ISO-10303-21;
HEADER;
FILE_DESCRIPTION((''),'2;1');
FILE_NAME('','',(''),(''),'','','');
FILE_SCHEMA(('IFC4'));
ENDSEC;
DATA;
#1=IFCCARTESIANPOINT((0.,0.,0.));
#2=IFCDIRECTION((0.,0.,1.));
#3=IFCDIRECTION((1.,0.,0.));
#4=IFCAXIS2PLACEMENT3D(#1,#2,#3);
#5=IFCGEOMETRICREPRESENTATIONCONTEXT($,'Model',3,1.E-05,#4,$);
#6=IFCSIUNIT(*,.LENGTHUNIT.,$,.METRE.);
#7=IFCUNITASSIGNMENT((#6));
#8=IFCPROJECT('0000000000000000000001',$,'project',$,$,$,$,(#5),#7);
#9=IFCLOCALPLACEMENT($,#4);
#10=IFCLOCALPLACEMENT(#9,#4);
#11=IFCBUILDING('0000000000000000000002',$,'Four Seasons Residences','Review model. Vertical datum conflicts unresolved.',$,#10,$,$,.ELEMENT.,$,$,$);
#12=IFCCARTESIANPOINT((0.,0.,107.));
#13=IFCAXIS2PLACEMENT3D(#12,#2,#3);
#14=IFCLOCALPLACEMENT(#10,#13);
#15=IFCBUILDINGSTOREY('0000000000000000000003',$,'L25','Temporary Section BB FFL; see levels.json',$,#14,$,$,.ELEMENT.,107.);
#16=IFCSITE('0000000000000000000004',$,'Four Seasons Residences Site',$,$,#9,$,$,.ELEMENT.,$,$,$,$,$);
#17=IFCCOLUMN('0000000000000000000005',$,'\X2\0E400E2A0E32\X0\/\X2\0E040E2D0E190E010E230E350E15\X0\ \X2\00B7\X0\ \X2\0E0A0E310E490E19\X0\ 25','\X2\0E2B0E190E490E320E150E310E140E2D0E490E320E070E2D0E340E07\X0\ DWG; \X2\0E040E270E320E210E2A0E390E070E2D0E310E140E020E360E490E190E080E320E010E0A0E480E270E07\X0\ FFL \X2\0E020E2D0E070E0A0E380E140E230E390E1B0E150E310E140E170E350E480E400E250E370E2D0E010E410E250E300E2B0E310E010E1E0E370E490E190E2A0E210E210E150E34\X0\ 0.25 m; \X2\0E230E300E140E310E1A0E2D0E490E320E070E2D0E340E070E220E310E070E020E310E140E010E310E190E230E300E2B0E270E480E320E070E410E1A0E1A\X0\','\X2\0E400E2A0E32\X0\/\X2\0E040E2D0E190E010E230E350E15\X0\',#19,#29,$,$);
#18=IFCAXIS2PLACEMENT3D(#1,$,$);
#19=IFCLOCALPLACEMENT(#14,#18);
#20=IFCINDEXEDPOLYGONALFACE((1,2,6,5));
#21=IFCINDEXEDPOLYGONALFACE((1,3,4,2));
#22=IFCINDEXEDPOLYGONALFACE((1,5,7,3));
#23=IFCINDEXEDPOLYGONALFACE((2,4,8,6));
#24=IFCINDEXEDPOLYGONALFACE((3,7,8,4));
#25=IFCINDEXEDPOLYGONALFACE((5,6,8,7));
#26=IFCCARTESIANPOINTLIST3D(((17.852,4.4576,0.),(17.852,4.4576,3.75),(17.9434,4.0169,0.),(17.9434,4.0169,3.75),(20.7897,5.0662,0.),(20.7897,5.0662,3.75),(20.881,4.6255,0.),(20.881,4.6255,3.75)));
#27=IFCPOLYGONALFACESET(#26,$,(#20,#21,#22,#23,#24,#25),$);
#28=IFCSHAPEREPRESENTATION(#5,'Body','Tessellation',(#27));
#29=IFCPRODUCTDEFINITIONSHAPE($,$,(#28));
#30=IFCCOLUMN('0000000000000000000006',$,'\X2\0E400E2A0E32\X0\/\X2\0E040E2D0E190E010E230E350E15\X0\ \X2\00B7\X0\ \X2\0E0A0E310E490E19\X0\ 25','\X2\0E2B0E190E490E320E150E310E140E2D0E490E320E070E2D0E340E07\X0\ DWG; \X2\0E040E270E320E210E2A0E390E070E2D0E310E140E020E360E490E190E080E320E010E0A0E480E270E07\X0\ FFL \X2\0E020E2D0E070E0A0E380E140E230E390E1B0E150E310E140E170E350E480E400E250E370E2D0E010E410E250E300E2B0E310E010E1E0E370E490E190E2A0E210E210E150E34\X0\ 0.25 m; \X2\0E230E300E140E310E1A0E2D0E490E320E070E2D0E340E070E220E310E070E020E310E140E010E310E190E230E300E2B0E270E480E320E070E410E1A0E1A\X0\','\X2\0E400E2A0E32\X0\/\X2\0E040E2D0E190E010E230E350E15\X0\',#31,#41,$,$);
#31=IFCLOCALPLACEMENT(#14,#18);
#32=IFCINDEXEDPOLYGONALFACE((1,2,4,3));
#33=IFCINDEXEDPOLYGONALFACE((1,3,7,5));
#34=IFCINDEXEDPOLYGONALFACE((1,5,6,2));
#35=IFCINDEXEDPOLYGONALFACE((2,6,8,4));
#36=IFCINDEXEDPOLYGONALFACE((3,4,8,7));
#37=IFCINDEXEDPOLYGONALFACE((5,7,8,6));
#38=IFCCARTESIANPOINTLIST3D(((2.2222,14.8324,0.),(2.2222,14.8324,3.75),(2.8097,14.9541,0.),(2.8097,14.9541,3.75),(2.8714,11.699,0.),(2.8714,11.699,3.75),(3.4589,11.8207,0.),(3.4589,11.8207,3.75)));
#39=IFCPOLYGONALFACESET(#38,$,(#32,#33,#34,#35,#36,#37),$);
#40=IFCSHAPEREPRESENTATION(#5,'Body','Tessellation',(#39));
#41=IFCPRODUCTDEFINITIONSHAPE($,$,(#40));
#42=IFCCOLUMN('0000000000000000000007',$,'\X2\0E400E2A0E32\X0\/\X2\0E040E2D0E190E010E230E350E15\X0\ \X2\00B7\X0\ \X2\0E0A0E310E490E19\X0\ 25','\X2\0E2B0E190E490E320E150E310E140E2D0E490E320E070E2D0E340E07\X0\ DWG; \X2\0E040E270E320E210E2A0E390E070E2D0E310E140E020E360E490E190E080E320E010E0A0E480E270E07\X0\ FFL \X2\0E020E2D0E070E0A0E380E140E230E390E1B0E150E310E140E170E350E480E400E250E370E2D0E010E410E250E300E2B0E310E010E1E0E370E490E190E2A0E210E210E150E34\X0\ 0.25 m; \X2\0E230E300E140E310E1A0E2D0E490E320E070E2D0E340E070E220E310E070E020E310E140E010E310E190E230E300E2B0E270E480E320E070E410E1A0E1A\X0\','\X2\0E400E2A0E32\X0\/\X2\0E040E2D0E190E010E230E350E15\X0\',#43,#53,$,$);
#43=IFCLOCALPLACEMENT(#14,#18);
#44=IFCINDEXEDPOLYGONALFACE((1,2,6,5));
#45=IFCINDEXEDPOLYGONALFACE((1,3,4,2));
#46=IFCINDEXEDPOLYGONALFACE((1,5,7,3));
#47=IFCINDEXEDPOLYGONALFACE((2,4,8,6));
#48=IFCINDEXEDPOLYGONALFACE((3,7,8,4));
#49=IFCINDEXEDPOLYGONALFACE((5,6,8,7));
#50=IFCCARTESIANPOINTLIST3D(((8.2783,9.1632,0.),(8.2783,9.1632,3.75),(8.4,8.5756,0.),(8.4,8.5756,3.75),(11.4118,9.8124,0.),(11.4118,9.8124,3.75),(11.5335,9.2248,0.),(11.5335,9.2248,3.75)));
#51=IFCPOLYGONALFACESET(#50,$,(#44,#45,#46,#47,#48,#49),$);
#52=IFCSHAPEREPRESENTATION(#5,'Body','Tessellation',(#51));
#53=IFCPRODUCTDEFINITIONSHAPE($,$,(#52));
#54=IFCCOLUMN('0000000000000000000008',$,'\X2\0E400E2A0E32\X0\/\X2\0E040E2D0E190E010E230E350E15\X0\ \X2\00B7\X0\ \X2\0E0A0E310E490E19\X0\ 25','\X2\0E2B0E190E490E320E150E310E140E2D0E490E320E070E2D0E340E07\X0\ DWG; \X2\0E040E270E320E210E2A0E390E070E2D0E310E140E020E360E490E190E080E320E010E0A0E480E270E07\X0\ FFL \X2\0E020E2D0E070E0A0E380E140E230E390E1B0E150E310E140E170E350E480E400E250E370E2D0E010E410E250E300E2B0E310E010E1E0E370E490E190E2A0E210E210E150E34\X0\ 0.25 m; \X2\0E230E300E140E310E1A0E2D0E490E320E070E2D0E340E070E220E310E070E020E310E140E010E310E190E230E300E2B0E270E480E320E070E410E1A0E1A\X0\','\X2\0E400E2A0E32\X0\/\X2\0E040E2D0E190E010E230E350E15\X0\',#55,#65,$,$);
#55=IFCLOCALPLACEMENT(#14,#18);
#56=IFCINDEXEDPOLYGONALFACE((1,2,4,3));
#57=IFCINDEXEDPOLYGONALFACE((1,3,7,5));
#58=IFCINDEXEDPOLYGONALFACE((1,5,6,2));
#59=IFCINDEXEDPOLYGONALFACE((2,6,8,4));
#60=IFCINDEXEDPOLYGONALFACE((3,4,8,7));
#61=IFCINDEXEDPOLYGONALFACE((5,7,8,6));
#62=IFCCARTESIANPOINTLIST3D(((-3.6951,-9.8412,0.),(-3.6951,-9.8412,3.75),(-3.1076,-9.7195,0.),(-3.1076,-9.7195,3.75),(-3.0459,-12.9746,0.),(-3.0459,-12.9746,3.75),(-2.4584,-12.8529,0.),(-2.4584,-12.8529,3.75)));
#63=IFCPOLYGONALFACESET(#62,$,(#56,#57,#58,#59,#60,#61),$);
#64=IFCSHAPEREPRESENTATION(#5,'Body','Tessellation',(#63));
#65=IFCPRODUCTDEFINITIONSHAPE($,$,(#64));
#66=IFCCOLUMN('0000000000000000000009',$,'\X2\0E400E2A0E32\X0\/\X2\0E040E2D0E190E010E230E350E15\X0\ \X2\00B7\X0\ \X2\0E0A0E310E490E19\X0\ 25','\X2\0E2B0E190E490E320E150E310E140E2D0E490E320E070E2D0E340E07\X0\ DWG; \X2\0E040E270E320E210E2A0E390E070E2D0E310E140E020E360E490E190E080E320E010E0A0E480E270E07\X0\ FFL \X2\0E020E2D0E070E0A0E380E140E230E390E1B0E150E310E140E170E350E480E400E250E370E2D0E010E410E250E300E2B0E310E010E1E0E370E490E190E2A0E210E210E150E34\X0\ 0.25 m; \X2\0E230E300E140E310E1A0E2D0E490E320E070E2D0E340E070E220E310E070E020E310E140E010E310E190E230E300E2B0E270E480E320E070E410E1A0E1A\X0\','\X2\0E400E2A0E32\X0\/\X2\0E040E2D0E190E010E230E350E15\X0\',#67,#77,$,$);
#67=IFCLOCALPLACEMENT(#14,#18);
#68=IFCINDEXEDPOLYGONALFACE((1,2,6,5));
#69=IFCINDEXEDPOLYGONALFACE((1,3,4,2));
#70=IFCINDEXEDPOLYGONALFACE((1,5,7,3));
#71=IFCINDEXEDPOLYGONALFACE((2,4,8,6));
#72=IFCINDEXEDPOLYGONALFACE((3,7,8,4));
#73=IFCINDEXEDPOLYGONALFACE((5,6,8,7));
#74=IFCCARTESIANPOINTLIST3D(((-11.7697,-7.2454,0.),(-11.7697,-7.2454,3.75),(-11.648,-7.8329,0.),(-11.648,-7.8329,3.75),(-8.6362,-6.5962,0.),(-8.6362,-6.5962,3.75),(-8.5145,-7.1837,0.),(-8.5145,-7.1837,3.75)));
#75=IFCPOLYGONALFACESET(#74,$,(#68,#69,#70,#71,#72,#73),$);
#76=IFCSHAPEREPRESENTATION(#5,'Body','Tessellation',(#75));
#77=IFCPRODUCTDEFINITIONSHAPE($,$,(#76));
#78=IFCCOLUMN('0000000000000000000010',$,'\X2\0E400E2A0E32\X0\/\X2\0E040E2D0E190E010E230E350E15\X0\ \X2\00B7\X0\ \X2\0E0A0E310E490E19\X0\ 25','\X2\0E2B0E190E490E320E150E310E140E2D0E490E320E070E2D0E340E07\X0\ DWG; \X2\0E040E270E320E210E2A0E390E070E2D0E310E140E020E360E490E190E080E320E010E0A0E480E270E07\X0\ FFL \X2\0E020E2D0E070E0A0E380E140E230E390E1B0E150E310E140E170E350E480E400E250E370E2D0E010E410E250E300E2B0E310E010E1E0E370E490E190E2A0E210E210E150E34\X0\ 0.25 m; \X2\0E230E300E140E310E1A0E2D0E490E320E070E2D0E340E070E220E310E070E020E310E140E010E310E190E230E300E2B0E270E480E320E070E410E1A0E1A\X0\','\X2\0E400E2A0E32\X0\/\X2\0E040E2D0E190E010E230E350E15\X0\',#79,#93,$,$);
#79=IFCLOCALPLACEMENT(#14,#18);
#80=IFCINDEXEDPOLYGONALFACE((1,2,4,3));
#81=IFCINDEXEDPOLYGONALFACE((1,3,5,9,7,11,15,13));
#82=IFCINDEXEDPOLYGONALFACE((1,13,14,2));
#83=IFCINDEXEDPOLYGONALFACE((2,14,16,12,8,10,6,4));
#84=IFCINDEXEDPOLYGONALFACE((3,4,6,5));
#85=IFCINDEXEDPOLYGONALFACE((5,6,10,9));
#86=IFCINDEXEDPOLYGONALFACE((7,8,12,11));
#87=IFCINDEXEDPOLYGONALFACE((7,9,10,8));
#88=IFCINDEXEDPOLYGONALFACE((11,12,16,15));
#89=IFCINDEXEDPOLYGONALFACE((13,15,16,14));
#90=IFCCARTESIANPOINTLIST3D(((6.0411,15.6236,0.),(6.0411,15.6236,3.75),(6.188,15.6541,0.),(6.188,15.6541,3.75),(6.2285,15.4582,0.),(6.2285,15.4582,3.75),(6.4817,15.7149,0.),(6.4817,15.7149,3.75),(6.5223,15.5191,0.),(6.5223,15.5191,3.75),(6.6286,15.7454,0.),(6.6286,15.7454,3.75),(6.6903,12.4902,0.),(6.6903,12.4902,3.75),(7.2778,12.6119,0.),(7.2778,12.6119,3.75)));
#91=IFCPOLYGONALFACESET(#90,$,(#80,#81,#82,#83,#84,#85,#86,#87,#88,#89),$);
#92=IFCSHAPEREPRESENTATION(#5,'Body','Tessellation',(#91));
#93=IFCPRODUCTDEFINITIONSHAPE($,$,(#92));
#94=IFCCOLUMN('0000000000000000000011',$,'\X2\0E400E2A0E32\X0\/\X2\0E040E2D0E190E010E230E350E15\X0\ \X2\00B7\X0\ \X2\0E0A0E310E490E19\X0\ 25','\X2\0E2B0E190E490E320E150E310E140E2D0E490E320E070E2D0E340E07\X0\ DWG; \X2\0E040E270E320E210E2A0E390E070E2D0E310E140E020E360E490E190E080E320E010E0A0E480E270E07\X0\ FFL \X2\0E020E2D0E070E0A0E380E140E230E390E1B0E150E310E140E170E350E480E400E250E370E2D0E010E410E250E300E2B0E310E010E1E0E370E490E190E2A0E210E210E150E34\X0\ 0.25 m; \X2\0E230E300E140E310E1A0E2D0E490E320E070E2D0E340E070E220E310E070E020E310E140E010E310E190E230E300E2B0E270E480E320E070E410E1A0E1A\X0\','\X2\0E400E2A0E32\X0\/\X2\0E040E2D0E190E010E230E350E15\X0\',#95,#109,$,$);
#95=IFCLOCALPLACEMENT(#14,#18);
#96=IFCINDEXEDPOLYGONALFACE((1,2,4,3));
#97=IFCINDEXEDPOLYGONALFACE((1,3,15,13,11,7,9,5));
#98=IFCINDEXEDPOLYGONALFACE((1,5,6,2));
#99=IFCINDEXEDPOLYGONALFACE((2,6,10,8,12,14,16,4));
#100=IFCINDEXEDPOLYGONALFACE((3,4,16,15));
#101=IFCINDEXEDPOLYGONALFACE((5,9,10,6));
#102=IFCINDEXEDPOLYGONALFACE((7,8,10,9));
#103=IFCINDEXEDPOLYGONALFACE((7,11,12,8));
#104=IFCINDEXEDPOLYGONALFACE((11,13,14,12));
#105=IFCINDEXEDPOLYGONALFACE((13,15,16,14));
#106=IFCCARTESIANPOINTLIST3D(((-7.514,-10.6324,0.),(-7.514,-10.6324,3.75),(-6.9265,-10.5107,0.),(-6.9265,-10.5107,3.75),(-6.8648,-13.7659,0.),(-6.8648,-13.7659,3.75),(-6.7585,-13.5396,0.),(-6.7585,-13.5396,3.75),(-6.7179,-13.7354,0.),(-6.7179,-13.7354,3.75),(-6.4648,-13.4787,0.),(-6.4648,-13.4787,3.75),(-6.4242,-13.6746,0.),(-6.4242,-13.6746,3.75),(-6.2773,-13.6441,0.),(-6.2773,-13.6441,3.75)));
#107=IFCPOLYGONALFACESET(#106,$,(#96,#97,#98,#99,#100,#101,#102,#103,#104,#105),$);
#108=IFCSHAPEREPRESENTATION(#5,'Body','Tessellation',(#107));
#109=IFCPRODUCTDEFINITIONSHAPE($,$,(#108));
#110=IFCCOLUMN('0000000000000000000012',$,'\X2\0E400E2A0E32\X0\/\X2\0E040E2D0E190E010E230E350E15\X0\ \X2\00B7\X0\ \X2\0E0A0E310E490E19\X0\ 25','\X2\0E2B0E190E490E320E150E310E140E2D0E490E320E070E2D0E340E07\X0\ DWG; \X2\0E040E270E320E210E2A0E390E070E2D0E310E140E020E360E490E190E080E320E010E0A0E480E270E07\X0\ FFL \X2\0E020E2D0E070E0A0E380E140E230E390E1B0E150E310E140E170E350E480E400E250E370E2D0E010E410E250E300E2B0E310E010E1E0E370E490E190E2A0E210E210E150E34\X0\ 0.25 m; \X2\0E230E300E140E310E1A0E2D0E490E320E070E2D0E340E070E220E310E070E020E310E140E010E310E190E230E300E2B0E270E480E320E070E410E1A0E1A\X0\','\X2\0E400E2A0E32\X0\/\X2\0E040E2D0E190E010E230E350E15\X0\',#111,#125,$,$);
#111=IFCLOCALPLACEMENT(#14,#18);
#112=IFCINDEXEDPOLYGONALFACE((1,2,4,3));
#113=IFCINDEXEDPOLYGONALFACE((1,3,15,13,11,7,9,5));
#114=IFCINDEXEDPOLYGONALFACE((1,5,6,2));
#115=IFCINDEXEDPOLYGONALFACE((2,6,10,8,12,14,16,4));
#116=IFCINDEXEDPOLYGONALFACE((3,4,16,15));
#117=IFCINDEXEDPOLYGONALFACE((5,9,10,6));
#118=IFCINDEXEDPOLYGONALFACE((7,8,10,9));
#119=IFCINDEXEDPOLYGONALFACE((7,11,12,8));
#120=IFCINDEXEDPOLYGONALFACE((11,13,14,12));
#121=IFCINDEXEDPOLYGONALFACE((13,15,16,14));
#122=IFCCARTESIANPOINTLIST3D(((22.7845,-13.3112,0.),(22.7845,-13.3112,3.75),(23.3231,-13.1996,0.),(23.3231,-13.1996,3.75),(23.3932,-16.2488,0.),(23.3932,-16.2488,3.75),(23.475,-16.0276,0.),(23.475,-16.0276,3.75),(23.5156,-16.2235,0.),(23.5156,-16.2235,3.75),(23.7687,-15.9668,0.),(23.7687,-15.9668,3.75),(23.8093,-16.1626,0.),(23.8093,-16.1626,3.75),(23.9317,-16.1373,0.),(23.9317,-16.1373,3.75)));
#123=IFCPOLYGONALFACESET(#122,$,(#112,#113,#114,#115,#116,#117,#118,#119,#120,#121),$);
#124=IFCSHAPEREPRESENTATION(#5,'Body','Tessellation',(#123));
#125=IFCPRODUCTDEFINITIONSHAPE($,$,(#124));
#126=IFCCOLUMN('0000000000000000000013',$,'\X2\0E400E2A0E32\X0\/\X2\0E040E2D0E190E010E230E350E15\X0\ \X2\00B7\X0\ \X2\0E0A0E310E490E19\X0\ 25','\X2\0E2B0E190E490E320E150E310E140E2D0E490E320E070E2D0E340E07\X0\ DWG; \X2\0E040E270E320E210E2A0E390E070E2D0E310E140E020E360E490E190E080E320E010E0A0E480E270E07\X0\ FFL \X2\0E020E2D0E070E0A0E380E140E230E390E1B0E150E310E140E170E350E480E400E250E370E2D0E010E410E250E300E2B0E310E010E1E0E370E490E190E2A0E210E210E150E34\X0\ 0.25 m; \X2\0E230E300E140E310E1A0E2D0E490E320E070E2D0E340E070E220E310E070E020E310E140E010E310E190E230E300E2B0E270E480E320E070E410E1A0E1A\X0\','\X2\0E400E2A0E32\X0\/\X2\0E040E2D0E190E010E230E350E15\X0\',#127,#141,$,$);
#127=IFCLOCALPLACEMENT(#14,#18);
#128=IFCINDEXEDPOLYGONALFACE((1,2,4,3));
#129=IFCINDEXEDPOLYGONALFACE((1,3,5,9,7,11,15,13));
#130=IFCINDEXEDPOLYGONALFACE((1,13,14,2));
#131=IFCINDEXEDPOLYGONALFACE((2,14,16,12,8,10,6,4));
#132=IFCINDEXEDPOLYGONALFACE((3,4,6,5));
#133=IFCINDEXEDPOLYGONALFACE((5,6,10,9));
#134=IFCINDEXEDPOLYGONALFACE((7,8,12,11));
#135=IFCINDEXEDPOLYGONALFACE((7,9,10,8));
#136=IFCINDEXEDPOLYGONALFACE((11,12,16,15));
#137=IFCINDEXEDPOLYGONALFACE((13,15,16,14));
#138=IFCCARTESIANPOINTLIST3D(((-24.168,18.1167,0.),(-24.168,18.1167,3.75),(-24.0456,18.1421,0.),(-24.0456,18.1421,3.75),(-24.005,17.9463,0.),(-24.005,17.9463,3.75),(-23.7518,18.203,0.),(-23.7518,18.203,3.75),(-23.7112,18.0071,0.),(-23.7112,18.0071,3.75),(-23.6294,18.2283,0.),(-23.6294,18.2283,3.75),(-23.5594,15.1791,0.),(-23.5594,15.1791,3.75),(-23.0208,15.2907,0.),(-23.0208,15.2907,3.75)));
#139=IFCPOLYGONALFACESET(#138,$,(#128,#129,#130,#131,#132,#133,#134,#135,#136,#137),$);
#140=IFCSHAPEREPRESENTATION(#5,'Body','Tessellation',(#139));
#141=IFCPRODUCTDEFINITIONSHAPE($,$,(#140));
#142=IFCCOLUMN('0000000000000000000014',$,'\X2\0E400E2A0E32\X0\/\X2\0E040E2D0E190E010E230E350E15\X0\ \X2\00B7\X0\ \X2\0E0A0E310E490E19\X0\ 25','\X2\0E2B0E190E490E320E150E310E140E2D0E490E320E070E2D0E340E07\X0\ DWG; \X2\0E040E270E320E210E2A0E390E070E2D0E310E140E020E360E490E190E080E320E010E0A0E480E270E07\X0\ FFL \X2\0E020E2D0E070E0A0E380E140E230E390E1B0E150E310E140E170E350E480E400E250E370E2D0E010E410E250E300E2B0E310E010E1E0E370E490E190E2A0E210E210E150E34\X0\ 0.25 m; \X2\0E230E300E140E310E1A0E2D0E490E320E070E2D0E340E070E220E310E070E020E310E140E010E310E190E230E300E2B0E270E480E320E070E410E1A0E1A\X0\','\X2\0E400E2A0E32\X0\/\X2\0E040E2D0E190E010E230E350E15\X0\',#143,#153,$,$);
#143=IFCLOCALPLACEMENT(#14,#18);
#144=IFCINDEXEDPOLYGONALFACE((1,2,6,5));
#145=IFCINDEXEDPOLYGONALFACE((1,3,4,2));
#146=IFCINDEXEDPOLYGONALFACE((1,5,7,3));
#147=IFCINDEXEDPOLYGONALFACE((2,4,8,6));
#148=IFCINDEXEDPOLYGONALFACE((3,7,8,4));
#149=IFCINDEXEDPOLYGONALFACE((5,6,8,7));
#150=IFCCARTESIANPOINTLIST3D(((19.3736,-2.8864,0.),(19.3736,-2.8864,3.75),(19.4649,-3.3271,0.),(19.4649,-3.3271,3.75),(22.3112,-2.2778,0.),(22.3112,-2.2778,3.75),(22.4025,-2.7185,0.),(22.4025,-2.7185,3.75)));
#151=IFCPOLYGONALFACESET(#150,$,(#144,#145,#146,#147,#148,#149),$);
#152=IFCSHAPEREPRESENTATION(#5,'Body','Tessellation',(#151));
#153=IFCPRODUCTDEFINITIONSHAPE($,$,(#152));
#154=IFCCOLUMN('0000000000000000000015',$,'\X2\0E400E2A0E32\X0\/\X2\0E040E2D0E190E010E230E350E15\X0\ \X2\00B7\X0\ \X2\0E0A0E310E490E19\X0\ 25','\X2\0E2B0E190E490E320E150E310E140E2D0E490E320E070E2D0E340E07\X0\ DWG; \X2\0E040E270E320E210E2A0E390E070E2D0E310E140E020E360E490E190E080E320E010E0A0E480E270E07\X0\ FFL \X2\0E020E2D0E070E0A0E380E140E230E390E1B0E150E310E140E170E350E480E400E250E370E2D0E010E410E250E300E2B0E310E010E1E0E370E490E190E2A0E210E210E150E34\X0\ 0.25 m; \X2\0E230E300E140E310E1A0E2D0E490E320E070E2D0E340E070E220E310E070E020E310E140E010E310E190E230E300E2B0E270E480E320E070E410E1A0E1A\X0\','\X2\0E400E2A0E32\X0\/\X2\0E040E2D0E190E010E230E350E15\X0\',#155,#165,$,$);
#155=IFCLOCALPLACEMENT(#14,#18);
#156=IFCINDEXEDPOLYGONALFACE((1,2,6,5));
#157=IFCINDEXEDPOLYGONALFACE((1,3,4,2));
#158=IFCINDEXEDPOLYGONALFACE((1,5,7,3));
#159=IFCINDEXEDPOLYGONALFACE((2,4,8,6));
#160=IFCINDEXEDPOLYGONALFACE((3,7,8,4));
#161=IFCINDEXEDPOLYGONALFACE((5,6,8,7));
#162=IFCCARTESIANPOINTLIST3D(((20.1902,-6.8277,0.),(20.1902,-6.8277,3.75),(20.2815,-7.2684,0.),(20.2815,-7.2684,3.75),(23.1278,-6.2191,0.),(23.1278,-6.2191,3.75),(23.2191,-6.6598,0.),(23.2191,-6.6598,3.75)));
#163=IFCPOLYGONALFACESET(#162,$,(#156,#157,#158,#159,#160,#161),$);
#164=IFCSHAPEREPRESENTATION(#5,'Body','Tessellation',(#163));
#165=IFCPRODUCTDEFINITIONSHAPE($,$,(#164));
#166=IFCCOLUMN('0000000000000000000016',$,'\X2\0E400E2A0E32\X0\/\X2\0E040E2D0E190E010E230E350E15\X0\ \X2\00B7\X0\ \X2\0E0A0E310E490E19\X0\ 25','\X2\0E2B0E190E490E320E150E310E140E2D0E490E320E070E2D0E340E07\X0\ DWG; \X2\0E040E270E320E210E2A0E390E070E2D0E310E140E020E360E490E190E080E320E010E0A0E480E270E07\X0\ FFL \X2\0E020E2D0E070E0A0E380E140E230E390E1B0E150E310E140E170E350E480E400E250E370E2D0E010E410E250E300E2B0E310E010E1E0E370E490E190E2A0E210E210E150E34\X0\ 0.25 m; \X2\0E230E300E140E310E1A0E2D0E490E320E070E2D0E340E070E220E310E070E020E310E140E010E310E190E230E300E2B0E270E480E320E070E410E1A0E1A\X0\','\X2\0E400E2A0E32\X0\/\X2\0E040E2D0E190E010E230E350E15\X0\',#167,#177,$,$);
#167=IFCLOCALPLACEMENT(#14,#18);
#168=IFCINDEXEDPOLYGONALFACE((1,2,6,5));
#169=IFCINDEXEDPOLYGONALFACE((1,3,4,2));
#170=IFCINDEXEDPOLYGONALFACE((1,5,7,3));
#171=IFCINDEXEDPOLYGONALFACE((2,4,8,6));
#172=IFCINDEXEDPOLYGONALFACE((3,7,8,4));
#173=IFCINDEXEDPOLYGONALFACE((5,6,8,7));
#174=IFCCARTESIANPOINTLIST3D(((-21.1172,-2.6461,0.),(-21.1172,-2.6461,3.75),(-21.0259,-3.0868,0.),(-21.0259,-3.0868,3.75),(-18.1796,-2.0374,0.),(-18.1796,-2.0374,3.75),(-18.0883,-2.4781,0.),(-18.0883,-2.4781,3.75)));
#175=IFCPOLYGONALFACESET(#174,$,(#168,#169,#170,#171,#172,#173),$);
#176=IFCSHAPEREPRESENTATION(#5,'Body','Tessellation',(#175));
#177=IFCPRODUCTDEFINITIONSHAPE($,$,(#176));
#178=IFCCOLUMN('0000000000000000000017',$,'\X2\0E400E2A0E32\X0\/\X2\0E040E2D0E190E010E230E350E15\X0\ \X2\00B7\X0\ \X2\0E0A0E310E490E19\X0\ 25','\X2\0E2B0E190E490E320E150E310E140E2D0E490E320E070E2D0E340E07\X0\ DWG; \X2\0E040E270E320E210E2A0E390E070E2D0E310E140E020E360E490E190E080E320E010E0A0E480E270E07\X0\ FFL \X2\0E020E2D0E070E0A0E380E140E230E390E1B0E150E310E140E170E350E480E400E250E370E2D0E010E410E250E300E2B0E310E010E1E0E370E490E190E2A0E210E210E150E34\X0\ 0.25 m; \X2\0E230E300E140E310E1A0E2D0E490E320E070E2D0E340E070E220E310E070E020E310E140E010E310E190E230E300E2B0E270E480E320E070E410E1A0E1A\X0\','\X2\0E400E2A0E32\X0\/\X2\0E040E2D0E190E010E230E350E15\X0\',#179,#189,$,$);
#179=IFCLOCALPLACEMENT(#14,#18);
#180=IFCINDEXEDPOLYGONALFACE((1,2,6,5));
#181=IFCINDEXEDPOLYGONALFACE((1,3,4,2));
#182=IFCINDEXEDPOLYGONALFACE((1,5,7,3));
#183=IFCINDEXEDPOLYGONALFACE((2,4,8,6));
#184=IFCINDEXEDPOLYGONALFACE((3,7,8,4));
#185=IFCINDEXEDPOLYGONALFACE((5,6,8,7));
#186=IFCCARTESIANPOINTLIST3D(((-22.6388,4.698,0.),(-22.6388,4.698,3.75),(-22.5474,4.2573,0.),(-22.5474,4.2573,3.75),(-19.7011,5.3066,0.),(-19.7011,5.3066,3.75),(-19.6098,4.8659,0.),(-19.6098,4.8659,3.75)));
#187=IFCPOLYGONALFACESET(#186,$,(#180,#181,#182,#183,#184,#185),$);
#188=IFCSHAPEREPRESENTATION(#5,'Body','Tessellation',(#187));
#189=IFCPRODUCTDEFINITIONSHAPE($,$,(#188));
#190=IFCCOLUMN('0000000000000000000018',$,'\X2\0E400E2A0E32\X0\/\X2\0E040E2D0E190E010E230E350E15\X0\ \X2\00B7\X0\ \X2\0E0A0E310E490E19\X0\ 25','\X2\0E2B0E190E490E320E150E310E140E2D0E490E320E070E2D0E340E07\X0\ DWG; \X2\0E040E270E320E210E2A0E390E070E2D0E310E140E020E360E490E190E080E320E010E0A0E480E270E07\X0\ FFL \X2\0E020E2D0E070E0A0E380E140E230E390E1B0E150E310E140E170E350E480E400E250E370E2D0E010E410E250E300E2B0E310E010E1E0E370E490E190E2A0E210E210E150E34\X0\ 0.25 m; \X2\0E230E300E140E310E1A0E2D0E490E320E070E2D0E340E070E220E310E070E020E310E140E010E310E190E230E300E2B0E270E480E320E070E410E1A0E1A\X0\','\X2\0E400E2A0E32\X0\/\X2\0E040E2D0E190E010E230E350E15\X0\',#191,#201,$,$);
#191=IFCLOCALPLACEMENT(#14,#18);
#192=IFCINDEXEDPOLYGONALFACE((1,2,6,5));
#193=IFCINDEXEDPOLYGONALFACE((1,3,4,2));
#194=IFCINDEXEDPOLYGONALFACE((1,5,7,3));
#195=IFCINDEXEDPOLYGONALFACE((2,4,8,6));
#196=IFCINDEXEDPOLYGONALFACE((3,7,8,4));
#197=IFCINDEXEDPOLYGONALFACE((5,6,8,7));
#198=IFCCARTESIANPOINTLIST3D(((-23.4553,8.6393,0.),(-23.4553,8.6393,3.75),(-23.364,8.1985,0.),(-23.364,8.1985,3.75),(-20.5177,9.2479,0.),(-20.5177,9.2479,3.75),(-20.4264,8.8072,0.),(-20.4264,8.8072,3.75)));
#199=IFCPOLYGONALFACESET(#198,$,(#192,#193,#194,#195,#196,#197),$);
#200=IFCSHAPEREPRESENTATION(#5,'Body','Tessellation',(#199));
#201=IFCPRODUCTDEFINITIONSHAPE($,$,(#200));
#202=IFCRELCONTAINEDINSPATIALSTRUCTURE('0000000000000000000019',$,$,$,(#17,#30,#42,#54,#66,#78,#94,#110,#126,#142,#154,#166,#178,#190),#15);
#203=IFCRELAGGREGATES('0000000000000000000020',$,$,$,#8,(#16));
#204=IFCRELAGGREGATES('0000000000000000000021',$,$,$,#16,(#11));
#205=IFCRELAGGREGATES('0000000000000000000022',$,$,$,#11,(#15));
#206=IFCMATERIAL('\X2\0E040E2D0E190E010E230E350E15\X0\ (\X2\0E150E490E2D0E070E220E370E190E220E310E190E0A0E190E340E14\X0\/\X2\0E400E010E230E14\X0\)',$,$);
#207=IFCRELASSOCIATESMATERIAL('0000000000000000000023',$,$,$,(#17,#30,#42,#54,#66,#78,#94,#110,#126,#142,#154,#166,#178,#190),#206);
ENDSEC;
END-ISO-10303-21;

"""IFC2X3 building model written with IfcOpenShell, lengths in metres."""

from ifc_helpers import new_model, si_unit, frame, origin_with_axes, place, context, project, spatial, polyline, outline, extrude, material, element, save


model = new_model("IFC2X3")

# Units and contexts
model_context = context("Model", 3, precision=1e-05, world=origin_with_axes())
ifc_project = project(units=[si_unit("LENGTHUNIT", "METRE")], contexts=[model_context])

# Site, building, storey
site_placement = place(None, origin_with_axes())
site = spatial("IfcSite", under=ifc_project, at=site_placement, Name="Four Seasons Residences Site", CompositionType="ELEMENT")
building_placement = place(site_placement, origin_with_axes())
building = spatial("IfcBuilding", under=site, at=building_placement, Name="Four Seasons Residences", Description="Review model. Vertical datum conflicts unresolved.", CompositionType="ELEMENT")
storey_placement = place(building_placement, frame((0.0, 0.0, 107.0), z_axis=(0.0, 0.0, 1.0), x_axis=(1.0, 0.0, 0.0)))
storey = spatial("IfcBuildingStorey", under=building, at=storey_placement, Name="L25", Description="Temporary Section BB FFL; see levels.json", CompositionType="ELEMENT", Elevation=107.0)

# Columns
ifc_material_1 = material(Name="คอนกรีต (ต้องยืนยันชนิด/เกรด)")
column_1_placement = place(storey_placement, origin_with_axes())
element("IfcColumn", 1, at=column_1_placement, inside=storey, material=ifc_material_1, Name="เสา/คอนกรีต · ชั้น 25", Description="หน้าตัดอ้างอิง DWG; ความสูงอัดขึ้นจากช่วง FFL ของชุดรูปตัดที่เลือกและหักพื้นสมมติ 0.25 m; ระดับอ้างอิงยังขัดกันระหว่างแบบ", ObjectType="เสา/คอนกรีต", context=model_context, shape_type="SweptSolid", body=[
    extrude(outline(polyline([(20.7897, 5.0662), (20.881, 4.6255), (17.9434, 4.0169), (17.852, 4.4576), (20.7897, 5.0662)])), origin_with_axes(), (0.0, 0.0, 1.0), 3.75),
])
column_2_placement = place(storey_placement, origin_with_axes())
element("IfcColumn", 2, at=column_2_placement, inside=storey, material=ifc_material_1, Name="เสา/คอนกรีต · ชั้น 25", Description="หน้าตัดอ้างอิง DWG; ความสูงอัดขึ้นจากช่วง FFL ของชุดรูปตัดที่เลือกและหักพื้นสมมติ 0.25 m; ระดับอ้างอิงยังขัดกันระหว่างแบบ", ObjectType="เสา/คอนกรีต", context=model_context, shape_type="SweptSolid", body=[
    extrude(outline(polyline([(2.8097, 14.9541), (3.4589, 11.8207), (2.8714, 11.699), (2.2222, 14.8324), (2.8097, 14.9541)])), origin_with_axes(), (0.0, 0.0, 1.0), 3.75),
])
column_3_placement = place(storey_placement, origin_with_axes())
element("IfcColumn", 3, at=column_3_placement, inside=storey, material=ifc_material_1, Name="เสา/คอนกรีต · ชั้น 25", Description="หน้าตัดอ้างอิง DWG; ความสูงอัดขึ้นจากช่วง FFL ของชุดรูปตัดที่เลือกและหักพื้นสมมติ 0.25 m; ระดับอ้างอิงยังขัดกันระหว่างแบบ", ObjectType="เสา/คอนกรีต", context=model_context, shape_type="SweptSolid", body=[
    extrude(outline(polyline([(11.5335, 9.2248), (8.4, 8.5756), (8.2783, 9.1632), (11.4118, 9.8124), (11.5335, 9.2248)])), origin_with_axes(), (0.0, 0.0, 1.0), 3.75),
])
column_4_placement = place(storey_placement, origin_with_axes())
element("IfcColumn", 4, at=column_4_placement, inside=storey, material=ifc_material_1, Name="เสา/คอนกรีต · ชั้น 25", Description="หน้าตัดอ้างอิง DWG; ความสูงอัดขึ้นจากช่วง FFL ของชุดรูปตัดที่เลือกและหักพื้นสมมติ 0.25 m; ระดับอ้างอิงยังขัดกันระหว่างแบบ", ObjectType="เสา/คอนกรีต", context=model_context, shape_type="SweptSolid", body=[
    extrude(outline(polyline([(-3.1076, -9.7195), (-2.4584, -12.8529), (-3.0459, -12.9746), (-3.6951, -9.8412), (-3.1076, -9.7195)])), origin_with_axes(), (0.0, 0.0, 1.0), 3.75),
])
column_5_placement = place(storey_placement, origin_with_axes())
element("IfcColumn", 5, at=column_5_placement, inside=storey, material=ifc_material_1, Name="เสา/คอนกรีต · ชั้น 25", Description="หน้าตัดอ้างอิง DWG; ความสูงอัดขึ้นจากช่วง FFL ของชุดรูปตัดที่เลือกและหักพื้นสมมติ 0.25 m; ระดับอ้างอิงยังขัดกันระหว่างแบบ", ObjectType="เสา/คอนกรีต", context=model_context, shape_type="SweptSolid", body=[
    extrude(outline(polyline([(-8.5145, -7.1837), (-11.648, -7.8329), (-11.7697, -7.2454), (-8.6362, -6.5962), (-8.5145, -7.1837)])), origin_with_axes(), (0.0, 0.0, 1.0), 3.75),
])
column_6_placement = place(storey_placement, origin_with_axes())
element("IfcColumn", 6, at=column_6_placement, inside=storey, material=ifc_material_1, Name="เสา/คอนกรีต · ชั้น 25", Description="หน้าตัดอ้างอิง DWG; ความสูงอัดขึ้นจากช่วง FFL ของชุดรูปตัดที่เลือกและหักพื้นสมมติ 0.25 m; ระดับอ้างอิงยังขัดกันระหว่างแบบ", ObjectType="เสา/คอนกรีต", context=model_context, shape_type="SweptSolid", body=[
    extrude(outline(polyline([(6.6286, 15.7454), (6.4817, 15.7149), (6.5223, 15.5191), (6.2285, 15.4582), (6.188, 15.6541), (6.0411, 15.6236), (6.6903, 12.4902), (7.2778, 12.6119), (6.6286, 15.7454)])), origin_with_axes(), (0.0, 0.0, 1.0), 3.75),
])
column_7_placement = place(storey_placement, origin_with_axes())
element("IfcColumn", 7, at=column_7_placement, inside=storey, material=ifc_material_1, Name="เสา/คอนกรีต · ชั้น 25", Description="หน้าตัดอ้างอิง DWG; ความสูงอัดขึ้นจากช่วง FFL ของชุดรูปตัดที่เลือกและหักพื้นสมมติ 0.25 m; ระดับอ้างอิงยังขัดกันระหว่างแบบ", ObjectType="เสา/คอนกรีต", context=model_context, shape_type="SweptSolid", body=[
    extrude(outline(polyline([(-6.2773, -13.6441), (-6.9265, -10.5107), (-7.514, -10.6324), (-6.8648, -13.7659), (-6.7179, -13.7354), (-6.7585, -13.5396), (-6.4648, -13.4787), (-6.4242, -13.6746), (-6.2773, -13.6441)])), origin_with_axes(), (0.0, 0.0, 1.0), 3.75),
])
column_8_placement = place(storey_placement, origin_with_axes())
element("IfcColumn", 8, at=column_8_placement, inside=storey, material=ifc_material_1, Name="เสา/คอนกรีต · ชั้น 25", Description="หน้าตัดอ้างอิง DWG; ความสูงอัดขึ้นจากช่วง FFL ของชุดรูปตัดที่เลือกและหักพื้นสมมติ 0.25 m; ระดับอ้างอิงยังขัดกันระหว่างแบบ", ObjectType="เสา/คอนกรีต", context=model_context, shape_type="SweptSolid", body=[
    extrude(outline(polyline([(23.9317, -16.1373), (23.3231, -13.1996), (22.7845, -13.3112), (23.3932, -16.2488), (23.5156, -16.2235), (23.475, -16.0276), (23.7687, -15.9668), (23.8093, -16.1626), (23.9317, -16.1373)])), origin_with_axes(), (0.0, 0.0, 1.0), 3.75),
])
column_9_placement = place(storey_placement, origin_with_axes())
element("IfcColumn", 9, at=column_9_placement, inside=storey, material=ifc_material_1, Name="เสา/คอนกรีต · ชั้น 25", Description="หน้าตัดอ้างอิง DWG; ความสูงอัดขึ้นจากช่วง FFL ของชุดรูปตัดที่เลือกและหักพื้นสมมติ 0.25 m; ระดับอ้างอิงยังขัดกันระหว่างแบบ", ObjectType="เสา/คอนกรีต", context=model_context, shape_type="SweptSolid", body=[
    extrude(outline(polyline([(-24.168, 18.1167), (-23.5594, 15.1791), (-23.0208, 15.2907), (-23.6294, 18.2283), (-23.7518, 18.203), (-23.7112, 18.0071), (-24.005, 17.9463), (-24.0456, 18.1421), (-24.168, 18.1167)])), origin_with_axes(), (0.0, 0.0, 1.0), 3.75),
])
column_10_placement = place(storey_placement, origin_with_axes())
element("IfcColumn", 10, at=column_10_placement, inside=storey, material=ifc_material_1, Name="เสา/คอนกรีต · ชั้น 25", Description="หน้าตัดอ้างอิง DWG; ความสูงอัดขึ้นจากช่วง FFL ของชุดรูปตัดที่เลือกและหักพื้นสมมติ 0.25 m; ระดับอ้างอิงยังขัดกันระหว่างแบบ", ObjectType="เสา/คอนกรีต", context=model_context, shape_type="SweptSolid", body=[
    extrude(outline(polyline([(22.3112, -2.2778), (22.4025, -2.7185), (19.4649, -3.3271), (19.3736, -2.8864), (22.3112, -2.2778)])), origin_with_axes(), (0.0, 0.0, 1.0), 3.75),
])
column_11_placement = place(storey_placement, origin_with_axes())
element("IfcColumn", 11, at=column_11_placement, inside=storey, material=ifc_material_1, Name="เสา/คอนกรีต · ชั้น 25", Description="หน้าตัดอ้างอิง DWG; ความสูงอัดขึ้นจากช่วง FFL ของชุดรูปตัดที่เลือกและหักพื้นสมมติ 0.25 m; ระดับอ้างอิงยังขัดกันระหว่างแบบ", ObjectType="เสา/คอนกรีต", context=model_context, shape_type="SweptSolid", body=[
    extrude(outline(polyline([(23.1278, -6.2191), (23.2191, -6.6598), (20.2815, -7.2684), (20.1902, -6.8277), (23.1278, -6.2191)])), origin_with_axes(), (0.0, 0.0, 1.0), 3.75),
])
column_12_placement = place(storey_placement, origin_with_axes())
element("IfcColumn", 12, at=column_12_placement, inside=storey, material=ifc_material_1, Name="เสา/คอนกรีต · ชั้น 25", Description="หน้าตัดอ้างอิง DWG; ความสูงอัดขึ้นจากช่วง FFL ของชุดรูปตัดที่เลือกและหักพื้นสมมติ 0.25 m; ระดับอ้างอิงยังขัดกันระหว่างแบบ", ObjectType="เสา/คอนกรีต", context=model_context, shape_type="SweptSolid", body=[
    extrude(outline(polyline([(-18.1796, -2.0374), (-18.0883, -2.4781), (-21.0259, -3.0868), (-21.1172, -2.6461), (-18.1796, -2.0374)])), origin_with_axes(), (0.0, 0.0, 1.0), 3.75),
])
column_13_placement = place(storey_placement, origin_with_axes())
element("IfcColumn", 13, at=column_13_placement, inside=storey, material=ifc_material_1, Name="เสา/คอนกรีต · ชั้น 25", Description="หน้าตัดอ้างอิง DWG; ความสูงอัดขึ้นจากช่วง FFL ของชุดรูปตัดที่เลือกและหักพื้นสมมติ 0.25 m; ระดับอ้างอิงยังขัดกันระหว่างแบบ", ObjectType="เสา/คอนกรีต", context=model_context, shape_type="SweptSolid", body=[
    extrude(outline(polyline([(-19.7011, 5.3066), (-19.6098, 4.8659), (-22.5474, 4.2573), (-22.6388, 4.698), (-19.7011, 5.3066)])), origin_with_axes(), (0.0, 0.0, 1.0), 3.75),
])
column_14_placement = place(storey_placement, origin_with_axes())
element("IfcColumn", 14, at=column_14_placement, inside=storey, material=ifc_material_1, Name="เสา/คอนกรีต · ชั้น 25", Description="หน้าตัดอ้างอิง DWG; ความสูงอัดขึ้นจากช่วง FFL ของชุดรูปตัดที่เลือกและหักพื้นสมมติ 0.25 m; ระดับอ้างอิงยังขัดกันระหว่างแบบ", ObjectType="เสา/คอนกรีต", context=model_context, shape_type="SweptSolid", body=[
    extrude(outline(polyline([(-20.5177, 9.2479), (-20.4264, 8.8072), (-23.364, 8.1985), (-23.4553, 8.6393), (-20.5177, 9.2479)])), origin_with_axes(), (0.0, 0.0, 1.0), 3.75),
])

save(model, "model.ifc")
